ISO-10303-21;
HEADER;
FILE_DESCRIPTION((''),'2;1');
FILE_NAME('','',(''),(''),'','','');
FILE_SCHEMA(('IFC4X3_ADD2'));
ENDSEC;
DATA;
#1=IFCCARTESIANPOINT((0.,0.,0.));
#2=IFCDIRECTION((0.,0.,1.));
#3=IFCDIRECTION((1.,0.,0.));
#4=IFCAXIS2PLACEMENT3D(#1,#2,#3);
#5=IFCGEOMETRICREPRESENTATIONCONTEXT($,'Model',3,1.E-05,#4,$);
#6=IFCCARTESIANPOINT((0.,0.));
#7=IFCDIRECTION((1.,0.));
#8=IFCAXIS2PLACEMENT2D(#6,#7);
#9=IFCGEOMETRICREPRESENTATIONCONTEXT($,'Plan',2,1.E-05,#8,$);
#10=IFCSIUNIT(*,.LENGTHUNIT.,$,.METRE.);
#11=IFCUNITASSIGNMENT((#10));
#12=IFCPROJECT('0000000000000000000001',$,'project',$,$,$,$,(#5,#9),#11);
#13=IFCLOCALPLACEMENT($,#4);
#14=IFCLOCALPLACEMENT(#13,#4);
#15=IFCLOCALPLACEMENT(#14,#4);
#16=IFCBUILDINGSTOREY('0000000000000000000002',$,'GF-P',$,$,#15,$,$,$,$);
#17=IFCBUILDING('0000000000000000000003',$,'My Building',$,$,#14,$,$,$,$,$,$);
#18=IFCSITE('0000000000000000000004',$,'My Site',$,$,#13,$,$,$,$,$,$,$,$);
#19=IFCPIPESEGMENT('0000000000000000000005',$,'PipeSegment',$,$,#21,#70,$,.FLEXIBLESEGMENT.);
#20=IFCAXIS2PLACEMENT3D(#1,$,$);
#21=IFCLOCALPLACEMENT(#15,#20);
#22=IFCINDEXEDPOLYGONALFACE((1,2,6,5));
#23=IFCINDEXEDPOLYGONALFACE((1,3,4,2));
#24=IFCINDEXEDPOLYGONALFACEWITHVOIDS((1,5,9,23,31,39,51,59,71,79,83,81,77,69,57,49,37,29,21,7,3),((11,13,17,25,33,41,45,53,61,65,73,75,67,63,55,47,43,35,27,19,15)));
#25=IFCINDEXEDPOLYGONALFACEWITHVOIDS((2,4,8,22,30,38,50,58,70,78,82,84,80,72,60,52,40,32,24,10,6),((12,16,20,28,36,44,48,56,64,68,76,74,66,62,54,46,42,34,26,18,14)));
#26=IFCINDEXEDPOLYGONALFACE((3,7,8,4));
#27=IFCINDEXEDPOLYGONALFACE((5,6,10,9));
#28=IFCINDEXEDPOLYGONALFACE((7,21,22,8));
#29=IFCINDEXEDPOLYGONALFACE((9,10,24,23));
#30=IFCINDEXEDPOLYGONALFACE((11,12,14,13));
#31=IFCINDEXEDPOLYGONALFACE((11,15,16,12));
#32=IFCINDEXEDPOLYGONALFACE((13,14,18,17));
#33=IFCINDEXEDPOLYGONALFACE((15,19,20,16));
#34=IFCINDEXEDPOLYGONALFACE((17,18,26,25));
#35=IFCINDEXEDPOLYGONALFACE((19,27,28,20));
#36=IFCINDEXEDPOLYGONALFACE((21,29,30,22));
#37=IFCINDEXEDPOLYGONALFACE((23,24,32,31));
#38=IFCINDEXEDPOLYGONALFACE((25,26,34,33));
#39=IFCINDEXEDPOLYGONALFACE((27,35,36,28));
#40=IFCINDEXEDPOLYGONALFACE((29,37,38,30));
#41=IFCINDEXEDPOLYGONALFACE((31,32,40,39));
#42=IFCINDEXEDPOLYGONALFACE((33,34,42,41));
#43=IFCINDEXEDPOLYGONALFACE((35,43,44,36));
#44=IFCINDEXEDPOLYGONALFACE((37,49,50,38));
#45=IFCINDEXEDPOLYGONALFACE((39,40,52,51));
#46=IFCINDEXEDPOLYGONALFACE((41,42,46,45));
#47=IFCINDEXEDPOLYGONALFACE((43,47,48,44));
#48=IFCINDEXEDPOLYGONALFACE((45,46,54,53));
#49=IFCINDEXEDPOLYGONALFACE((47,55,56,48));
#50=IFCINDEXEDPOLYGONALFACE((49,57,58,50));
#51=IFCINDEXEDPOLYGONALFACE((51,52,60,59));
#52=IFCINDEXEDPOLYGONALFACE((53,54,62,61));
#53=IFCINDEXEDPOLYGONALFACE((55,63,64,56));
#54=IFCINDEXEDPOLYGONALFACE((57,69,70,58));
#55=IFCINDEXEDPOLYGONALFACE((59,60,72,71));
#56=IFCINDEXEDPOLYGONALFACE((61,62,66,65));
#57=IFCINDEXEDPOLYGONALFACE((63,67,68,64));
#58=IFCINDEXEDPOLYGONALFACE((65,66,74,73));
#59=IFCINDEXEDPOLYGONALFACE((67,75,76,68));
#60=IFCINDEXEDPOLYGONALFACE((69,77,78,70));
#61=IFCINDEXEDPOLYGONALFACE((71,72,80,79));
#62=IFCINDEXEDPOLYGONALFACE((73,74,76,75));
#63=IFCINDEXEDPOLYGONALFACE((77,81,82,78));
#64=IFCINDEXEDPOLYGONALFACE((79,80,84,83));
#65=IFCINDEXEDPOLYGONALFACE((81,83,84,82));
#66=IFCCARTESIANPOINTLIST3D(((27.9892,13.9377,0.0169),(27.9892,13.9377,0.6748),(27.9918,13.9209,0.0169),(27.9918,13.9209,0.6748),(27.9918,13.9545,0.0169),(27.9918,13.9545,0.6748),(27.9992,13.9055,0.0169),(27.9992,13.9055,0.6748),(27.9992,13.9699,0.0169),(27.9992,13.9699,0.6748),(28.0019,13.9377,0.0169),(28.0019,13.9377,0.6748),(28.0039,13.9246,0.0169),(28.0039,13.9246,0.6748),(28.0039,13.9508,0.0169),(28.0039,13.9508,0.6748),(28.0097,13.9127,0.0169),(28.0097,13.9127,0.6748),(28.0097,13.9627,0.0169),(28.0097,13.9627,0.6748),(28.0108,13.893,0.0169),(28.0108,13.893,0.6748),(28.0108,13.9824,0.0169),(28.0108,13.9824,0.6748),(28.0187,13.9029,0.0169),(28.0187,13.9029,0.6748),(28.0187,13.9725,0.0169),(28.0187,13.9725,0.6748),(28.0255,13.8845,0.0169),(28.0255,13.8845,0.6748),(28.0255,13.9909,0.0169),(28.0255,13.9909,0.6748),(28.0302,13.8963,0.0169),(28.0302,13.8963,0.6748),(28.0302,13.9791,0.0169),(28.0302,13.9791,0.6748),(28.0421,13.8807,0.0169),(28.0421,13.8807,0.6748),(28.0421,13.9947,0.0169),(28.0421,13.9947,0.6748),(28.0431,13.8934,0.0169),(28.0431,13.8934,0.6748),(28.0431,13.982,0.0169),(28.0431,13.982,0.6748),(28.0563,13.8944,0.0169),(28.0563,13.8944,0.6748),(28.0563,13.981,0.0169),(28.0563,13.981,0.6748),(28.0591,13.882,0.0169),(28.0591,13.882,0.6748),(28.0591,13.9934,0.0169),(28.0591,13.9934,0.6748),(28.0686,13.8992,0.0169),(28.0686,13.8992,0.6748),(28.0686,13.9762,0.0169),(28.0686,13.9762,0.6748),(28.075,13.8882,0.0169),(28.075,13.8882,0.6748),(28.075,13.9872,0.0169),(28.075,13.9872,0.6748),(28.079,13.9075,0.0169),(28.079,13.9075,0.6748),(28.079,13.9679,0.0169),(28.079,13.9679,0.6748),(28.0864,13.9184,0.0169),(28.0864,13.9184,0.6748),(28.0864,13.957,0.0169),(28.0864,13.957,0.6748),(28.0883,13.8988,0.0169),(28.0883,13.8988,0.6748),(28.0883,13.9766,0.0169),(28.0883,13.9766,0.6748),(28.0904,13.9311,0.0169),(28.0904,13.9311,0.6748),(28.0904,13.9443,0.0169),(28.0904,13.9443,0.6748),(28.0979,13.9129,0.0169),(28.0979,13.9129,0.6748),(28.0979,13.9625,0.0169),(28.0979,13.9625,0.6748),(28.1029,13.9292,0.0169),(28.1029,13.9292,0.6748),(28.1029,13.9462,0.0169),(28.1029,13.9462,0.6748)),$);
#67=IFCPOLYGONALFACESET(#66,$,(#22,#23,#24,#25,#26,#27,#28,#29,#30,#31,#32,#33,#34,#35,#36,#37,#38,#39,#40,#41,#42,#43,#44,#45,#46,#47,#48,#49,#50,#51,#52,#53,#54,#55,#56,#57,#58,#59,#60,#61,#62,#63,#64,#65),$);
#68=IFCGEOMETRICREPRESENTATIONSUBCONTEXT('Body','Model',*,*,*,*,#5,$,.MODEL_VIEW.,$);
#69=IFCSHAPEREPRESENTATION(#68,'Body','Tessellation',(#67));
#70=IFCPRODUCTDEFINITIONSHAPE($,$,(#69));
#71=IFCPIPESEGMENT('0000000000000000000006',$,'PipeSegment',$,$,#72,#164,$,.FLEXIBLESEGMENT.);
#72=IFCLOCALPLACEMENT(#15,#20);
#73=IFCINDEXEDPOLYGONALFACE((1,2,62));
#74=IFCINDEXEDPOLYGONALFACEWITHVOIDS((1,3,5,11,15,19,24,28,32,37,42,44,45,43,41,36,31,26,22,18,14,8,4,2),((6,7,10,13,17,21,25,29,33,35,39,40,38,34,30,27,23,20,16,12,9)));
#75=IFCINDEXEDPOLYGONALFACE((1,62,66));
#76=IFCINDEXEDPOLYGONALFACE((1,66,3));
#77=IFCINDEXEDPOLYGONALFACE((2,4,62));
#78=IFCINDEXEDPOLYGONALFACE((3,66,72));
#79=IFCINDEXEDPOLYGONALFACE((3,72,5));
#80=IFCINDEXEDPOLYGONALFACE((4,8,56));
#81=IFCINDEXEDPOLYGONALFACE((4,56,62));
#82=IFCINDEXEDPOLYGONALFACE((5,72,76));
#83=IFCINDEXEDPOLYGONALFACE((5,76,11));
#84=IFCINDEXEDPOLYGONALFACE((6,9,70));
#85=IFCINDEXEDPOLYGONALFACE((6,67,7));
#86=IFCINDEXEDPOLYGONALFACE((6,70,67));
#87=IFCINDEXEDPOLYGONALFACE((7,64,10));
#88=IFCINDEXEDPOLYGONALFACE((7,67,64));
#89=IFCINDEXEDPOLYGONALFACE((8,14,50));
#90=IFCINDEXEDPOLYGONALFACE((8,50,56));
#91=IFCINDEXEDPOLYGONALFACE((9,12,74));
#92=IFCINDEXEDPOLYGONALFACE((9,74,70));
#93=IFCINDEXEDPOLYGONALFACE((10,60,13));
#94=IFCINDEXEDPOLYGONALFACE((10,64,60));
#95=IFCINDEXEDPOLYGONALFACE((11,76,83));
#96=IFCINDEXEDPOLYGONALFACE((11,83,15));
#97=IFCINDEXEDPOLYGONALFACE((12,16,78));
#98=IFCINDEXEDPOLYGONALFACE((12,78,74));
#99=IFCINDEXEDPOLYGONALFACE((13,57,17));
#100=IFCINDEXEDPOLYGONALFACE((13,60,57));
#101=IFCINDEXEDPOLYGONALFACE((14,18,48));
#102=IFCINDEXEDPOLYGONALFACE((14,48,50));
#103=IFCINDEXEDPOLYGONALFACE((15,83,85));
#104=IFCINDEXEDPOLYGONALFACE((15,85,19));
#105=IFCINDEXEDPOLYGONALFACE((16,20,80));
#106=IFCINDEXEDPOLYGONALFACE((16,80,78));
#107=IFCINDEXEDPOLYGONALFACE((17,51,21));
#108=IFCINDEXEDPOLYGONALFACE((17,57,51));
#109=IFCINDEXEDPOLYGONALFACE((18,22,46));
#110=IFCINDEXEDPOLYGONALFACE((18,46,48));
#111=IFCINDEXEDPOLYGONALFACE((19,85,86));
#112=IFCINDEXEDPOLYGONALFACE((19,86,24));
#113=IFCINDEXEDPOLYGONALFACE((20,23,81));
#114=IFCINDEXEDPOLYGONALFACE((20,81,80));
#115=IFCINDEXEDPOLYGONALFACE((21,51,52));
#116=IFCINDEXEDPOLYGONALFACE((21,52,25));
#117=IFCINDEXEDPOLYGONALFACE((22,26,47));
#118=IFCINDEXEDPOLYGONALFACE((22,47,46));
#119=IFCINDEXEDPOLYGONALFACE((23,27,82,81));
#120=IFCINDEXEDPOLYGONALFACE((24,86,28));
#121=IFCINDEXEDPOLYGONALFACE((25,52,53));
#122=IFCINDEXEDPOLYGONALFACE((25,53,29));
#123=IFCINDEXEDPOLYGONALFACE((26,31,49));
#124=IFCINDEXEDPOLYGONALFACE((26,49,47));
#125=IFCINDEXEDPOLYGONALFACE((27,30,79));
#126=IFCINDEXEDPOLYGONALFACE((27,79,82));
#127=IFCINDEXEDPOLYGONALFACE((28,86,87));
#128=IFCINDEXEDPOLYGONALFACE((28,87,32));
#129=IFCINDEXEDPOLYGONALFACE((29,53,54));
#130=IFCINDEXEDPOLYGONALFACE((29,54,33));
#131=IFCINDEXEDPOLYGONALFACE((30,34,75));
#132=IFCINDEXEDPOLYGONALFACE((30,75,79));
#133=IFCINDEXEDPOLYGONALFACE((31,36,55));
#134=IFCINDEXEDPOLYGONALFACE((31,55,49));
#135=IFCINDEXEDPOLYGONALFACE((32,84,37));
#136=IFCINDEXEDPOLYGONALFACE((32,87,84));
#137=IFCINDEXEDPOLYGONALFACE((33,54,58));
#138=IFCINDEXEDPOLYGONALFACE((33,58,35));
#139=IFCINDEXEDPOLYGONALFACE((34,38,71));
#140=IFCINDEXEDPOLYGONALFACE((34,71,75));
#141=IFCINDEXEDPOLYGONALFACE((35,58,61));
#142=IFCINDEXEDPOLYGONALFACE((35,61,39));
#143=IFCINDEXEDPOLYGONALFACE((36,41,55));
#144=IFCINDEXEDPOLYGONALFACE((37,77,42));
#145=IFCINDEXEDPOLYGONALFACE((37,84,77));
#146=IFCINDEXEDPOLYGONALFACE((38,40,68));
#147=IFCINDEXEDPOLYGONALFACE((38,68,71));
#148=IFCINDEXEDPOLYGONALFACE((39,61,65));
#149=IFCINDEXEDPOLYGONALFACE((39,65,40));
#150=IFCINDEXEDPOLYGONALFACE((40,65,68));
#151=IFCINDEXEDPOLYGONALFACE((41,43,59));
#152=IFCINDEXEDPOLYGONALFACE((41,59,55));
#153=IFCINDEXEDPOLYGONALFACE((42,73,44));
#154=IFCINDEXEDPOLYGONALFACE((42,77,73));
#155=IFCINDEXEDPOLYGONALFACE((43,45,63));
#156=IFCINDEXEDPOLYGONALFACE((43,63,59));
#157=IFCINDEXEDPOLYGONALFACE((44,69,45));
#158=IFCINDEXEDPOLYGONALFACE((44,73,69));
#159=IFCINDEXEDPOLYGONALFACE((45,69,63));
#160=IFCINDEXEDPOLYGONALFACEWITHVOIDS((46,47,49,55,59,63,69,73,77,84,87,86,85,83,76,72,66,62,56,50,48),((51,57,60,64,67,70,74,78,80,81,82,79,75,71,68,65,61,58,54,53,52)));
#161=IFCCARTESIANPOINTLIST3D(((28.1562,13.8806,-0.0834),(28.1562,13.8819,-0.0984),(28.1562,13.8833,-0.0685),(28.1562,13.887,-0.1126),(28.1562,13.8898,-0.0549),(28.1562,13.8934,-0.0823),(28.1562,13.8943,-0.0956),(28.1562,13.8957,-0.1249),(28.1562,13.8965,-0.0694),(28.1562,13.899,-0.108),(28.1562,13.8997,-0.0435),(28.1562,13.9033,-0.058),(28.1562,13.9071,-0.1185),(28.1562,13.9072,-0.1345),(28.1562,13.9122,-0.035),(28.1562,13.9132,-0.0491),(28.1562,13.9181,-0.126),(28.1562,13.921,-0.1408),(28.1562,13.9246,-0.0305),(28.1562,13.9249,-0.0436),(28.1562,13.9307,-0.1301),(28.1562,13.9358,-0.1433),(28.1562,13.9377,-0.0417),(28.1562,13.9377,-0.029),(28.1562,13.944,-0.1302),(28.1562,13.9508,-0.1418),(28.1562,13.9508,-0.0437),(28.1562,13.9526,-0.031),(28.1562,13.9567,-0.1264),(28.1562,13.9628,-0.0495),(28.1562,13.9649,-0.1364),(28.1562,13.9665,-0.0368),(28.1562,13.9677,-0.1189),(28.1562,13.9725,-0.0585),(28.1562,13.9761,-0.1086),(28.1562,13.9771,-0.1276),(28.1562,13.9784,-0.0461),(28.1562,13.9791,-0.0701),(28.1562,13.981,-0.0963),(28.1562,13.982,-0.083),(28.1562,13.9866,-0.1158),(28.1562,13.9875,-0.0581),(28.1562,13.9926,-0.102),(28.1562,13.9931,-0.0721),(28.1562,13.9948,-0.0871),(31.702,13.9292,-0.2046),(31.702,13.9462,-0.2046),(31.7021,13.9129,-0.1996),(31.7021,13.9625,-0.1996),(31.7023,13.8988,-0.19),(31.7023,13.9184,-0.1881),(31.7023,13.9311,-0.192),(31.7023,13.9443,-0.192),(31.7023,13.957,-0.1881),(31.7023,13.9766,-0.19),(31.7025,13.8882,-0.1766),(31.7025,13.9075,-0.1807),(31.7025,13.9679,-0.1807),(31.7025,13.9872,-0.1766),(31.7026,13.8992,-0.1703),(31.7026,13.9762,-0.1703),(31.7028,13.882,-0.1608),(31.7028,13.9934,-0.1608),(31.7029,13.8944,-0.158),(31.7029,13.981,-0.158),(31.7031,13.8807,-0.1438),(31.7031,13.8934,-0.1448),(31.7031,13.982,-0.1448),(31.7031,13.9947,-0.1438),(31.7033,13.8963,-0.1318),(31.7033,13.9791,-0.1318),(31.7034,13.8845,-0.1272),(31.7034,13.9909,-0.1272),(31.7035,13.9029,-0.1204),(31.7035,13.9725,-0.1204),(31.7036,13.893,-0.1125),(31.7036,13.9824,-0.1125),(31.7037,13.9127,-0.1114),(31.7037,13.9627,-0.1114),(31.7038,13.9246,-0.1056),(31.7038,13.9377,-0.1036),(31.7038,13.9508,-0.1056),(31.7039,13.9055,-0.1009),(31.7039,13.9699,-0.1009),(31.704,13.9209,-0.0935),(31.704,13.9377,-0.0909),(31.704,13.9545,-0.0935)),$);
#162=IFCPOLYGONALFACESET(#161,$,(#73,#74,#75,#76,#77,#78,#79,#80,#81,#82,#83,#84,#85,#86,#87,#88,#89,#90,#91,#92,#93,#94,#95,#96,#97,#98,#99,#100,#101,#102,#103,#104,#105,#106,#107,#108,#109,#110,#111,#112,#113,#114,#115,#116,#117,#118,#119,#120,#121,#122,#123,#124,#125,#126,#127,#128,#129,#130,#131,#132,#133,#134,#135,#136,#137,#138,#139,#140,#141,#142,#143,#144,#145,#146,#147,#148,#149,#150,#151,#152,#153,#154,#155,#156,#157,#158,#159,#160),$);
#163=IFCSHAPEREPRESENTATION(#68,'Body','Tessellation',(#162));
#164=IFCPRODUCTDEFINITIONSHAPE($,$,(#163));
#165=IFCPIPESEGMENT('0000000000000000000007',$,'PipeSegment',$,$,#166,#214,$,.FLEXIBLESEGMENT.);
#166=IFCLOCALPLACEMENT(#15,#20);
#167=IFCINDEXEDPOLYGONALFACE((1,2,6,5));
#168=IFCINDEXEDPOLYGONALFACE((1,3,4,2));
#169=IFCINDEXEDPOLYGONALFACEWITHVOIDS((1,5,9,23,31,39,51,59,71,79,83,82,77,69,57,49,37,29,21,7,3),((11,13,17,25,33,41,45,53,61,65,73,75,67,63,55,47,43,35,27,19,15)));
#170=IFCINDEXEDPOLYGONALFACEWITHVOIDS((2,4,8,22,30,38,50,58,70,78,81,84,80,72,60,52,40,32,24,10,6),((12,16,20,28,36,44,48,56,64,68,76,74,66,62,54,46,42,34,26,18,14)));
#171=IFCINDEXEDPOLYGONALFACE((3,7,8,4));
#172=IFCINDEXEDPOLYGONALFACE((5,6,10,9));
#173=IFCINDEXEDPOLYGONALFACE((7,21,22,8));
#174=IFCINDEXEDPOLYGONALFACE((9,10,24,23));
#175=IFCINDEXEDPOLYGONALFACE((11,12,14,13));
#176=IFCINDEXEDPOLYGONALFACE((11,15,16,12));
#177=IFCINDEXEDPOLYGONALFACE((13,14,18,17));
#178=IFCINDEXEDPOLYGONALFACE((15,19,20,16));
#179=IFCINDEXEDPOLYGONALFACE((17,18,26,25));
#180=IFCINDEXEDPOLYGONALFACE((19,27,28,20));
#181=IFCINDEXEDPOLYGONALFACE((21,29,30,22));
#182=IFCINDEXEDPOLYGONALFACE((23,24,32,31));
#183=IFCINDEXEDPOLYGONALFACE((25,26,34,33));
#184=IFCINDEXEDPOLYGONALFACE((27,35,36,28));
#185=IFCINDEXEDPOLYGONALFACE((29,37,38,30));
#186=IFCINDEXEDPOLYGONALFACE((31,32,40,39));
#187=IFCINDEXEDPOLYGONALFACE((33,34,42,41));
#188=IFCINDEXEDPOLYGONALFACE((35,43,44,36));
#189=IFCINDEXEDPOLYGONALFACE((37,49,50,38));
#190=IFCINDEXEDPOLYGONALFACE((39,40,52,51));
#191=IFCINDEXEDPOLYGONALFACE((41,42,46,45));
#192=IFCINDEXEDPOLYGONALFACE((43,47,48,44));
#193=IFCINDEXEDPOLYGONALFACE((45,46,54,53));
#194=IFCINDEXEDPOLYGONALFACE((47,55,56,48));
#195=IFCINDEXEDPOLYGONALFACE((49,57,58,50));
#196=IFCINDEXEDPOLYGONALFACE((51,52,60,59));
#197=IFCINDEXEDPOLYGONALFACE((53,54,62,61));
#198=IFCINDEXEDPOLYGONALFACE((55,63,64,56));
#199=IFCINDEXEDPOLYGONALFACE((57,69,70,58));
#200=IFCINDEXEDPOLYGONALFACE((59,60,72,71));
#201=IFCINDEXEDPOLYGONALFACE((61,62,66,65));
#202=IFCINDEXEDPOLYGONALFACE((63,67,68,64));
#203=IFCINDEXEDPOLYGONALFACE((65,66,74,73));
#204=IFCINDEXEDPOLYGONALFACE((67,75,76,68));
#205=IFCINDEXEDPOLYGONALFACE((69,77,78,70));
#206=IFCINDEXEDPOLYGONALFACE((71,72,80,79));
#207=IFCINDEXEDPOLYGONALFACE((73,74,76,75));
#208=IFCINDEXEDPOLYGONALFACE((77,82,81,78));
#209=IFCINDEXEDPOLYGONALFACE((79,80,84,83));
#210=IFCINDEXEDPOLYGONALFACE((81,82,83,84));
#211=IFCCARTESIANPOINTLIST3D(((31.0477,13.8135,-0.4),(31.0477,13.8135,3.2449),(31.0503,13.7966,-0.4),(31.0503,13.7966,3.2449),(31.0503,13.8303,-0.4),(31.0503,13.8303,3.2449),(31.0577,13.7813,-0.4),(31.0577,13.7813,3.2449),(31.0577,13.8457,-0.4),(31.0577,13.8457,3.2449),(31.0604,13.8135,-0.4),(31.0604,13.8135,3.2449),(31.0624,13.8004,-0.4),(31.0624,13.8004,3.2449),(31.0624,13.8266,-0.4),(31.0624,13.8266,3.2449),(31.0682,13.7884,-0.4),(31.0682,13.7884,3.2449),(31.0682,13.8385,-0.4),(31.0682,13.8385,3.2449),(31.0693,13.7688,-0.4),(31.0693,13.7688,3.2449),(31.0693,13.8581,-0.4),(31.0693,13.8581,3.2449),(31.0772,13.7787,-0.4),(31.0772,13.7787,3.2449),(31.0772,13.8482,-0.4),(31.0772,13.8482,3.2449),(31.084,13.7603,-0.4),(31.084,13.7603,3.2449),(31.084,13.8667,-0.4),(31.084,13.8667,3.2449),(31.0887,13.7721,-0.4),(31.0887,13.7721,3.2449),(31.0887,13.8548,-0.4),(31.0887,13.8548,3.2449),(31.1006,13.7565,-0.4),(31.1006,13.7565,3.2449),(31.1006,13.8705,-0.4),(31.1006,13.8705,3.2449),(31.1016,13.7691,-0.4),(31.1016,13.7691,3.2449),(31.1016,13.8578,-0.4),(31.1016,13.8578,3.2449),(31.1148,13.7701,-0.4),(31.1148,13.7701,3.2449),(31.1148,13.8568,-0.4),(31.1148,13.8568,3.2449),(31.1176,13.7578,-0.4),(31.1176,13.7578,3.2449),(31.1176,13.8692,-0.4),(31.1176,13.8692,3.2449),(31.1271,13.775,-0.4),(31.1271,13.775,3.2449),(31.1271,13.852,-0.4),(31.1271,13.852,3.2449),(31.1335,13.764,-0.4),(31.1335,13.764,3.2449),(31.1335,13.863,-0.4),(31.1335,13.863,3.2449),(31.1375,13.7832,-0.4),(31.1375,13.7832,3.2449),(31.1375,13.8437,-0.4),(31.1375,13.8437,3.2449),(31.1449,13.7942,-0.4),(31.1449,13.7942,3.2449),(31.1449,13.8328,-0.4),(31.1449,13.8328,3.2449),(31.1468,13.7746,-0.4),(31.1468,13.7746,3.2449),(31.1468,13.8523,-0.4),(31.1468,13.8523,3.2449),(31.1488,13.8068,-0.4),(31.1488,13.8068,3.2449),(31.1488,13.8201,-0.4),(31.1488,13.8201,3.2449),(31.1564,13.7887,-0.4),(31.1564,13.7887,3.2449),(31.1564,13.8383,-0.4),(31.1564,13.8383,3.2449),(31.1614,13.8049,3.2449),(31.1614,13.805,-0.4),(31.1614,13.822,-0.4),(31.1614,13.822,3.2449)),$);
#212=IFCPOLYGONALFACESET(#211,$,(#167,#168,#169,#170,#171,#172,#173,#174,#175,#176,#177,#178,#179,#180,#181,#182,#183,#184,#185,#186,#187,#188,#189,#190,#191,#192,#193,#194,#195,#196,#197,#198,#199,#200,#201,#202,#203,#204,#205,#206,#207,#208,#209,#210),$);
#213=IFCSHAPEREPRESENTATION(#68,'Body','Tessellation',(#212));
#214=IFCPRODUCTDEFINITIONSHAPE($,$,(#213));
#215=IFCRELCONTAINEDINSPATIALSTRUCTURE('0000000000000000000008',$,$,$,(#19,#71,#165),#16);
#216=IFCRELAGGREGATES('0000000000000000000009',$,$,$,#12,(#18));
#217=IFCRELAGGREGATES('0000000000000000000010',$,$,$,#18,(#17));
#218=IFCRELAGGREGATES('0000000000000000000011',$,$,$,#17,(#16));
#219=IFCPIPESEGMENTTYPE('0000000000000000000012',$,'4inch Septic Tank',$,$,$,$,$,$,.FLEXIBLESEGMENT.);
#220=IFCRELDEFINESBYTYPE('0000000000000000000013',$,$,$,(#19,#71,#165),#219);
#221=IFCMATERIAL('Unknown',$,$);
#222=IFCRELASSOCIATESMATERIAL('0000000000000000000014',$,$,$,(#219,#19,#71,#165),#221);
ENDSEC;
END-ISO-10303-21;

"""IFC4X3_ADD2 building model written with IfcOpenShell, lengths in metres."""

from ifc_helpers import new_model, si_unit, frame, origin_with_axes, origin_2d_with_axis, place, context, subcontext, project, spatial, hollow_circle, extrude, clip, halfspace, material, material_profile, profile_set, profile_usage, type_object, element, save


model = new_model("IFC4X3_ADD2")

# Units and contexts
model_context = context("Model", 3, precision=1e-05, world=origin_with_axes())
plan_context = context("Plan", 2, precision=1e-05, world=origin_2d_with_axis())
body_context = subcontext(model_context, "Body", "Model", "MODEL_VIEW")
ifc_project = project(units=[si_unit("LENGTHUNIT", "METRE")], contexts=[model_context, plan_context])

# Site, building, storey
site_placement = place(None, origin_with_axes())
site = spatial("IfcSite", under=ifc_project, at=site_placement, Name="My Site")
building_placement = place(site_placement, origin_with_axes())
building = spatial("IfcBuilding", under=site, at=building_placement, Name="My Building")
storey_placement = place(building_placement, origin_with_axes())
storey = spatial("IfcBuildingStorey", under=building, at=storey_placement, Name="GF-P")

# Pipe segments
ifc_material_1 = material(Name="Unknown")
ifc_material_profile_1 = material_profile(ifc_material_1, hollow_circle(Radius=0.0571, WallThickness=0.0127))
ifc_profile_set_1 = profile_set([ifc_material_profile_1], Name="blackwater")
ifc_profile_usage_1 = profile_usage(ifc_profile_set_1, cardinal=5)
pipe_segment_type_1 = type_object("IfcPipeSegmentType", Name="4inch Septic Tank", PredefinedType="FLEXIBLESEGMENT", material=ifc_profile_set_1)
pipe_segment_1_placement = place(storey_placement, frame((28.0464, 13.9377, 0.0169), z_axis=(0.0, 0.0, 1.0), x_axis=(-1.0, 0.0, 0.0)))
element("IfcPipeSegment", 1, at=pipe_segment_1_placement, inside=storey, type_object=pipe_segment_type_1, material=ifc_profile_usage_1, Name="PipeSegment", PredefinedType="FLEXIBLESEGMENT", context=body_context, shape_type="SweptSolid", body=[
    extrude(hollow_circle(Radius=0.0571, WallThickness=0.0127), origin_with_axes(), (0.0, 0.0, 1.0), 0.6579),
])
ifc_profile_usage_2 = profile_usage(ifc_profile_set_1, cardinal=5)
pipe_segment_2_placement = place(storey_placement, frame((28.0419, 13.9377, -0.0842), z_axis=(0.999848, 0.0, -0.017452), x_axis=(0.017452, 0.0, 0.999848)))
element("IfcPipeSegment", 2, at=pipe_segment_2_placement, inside=storey, type_object=pipe_segment_type_1, material=ifc_profile_usage_2, Name="PipeSegment", PredefinedType="FLEXIBLESEGMENT", context=body_context, shape_type="Clipping", body=[
    clip(extrude(hollow_circle(Radius=0.0571, WallThickness=0.0127), origin_with_axes(), (0.0, 0.0, 1.0), 3.6617), halfspace(frame((-0.0841, 0.1574, 0.1158), z_axis=(-0.017452, 0.000001, -0.999848), x_axis=(0.000031, 1.0, 0.0)), False)),
])
ifc_profile_usage_3 = profile_usage(ifc_profile_set_1, cardinal=5)
pipe_segment_3_placement = place(storey_placement, frame((31.1049, 13.8135, -0.4), z_axis=(0.0, 0.0, 1.0), x_axis=(-1.0, 0.0, 0.0)))
element("IfcPipeSegment", 3, at=pipe_segment_3_placement, inside=storey, type_object=pipe_segment_type_1, material=ifc_profile_usage_3, Name="PipeSegment", PredefinedType="FLEXIBLESEGMENT", context=body_context, shape_type="SweptSolid", body=[
    extrude(hollow_circle(Radius=0.0571, WallThickness=0.0127), origin_with_axes(), (0.0, 0.0, 1.0), 3.6449),
])

save(model, "model.ifc")
